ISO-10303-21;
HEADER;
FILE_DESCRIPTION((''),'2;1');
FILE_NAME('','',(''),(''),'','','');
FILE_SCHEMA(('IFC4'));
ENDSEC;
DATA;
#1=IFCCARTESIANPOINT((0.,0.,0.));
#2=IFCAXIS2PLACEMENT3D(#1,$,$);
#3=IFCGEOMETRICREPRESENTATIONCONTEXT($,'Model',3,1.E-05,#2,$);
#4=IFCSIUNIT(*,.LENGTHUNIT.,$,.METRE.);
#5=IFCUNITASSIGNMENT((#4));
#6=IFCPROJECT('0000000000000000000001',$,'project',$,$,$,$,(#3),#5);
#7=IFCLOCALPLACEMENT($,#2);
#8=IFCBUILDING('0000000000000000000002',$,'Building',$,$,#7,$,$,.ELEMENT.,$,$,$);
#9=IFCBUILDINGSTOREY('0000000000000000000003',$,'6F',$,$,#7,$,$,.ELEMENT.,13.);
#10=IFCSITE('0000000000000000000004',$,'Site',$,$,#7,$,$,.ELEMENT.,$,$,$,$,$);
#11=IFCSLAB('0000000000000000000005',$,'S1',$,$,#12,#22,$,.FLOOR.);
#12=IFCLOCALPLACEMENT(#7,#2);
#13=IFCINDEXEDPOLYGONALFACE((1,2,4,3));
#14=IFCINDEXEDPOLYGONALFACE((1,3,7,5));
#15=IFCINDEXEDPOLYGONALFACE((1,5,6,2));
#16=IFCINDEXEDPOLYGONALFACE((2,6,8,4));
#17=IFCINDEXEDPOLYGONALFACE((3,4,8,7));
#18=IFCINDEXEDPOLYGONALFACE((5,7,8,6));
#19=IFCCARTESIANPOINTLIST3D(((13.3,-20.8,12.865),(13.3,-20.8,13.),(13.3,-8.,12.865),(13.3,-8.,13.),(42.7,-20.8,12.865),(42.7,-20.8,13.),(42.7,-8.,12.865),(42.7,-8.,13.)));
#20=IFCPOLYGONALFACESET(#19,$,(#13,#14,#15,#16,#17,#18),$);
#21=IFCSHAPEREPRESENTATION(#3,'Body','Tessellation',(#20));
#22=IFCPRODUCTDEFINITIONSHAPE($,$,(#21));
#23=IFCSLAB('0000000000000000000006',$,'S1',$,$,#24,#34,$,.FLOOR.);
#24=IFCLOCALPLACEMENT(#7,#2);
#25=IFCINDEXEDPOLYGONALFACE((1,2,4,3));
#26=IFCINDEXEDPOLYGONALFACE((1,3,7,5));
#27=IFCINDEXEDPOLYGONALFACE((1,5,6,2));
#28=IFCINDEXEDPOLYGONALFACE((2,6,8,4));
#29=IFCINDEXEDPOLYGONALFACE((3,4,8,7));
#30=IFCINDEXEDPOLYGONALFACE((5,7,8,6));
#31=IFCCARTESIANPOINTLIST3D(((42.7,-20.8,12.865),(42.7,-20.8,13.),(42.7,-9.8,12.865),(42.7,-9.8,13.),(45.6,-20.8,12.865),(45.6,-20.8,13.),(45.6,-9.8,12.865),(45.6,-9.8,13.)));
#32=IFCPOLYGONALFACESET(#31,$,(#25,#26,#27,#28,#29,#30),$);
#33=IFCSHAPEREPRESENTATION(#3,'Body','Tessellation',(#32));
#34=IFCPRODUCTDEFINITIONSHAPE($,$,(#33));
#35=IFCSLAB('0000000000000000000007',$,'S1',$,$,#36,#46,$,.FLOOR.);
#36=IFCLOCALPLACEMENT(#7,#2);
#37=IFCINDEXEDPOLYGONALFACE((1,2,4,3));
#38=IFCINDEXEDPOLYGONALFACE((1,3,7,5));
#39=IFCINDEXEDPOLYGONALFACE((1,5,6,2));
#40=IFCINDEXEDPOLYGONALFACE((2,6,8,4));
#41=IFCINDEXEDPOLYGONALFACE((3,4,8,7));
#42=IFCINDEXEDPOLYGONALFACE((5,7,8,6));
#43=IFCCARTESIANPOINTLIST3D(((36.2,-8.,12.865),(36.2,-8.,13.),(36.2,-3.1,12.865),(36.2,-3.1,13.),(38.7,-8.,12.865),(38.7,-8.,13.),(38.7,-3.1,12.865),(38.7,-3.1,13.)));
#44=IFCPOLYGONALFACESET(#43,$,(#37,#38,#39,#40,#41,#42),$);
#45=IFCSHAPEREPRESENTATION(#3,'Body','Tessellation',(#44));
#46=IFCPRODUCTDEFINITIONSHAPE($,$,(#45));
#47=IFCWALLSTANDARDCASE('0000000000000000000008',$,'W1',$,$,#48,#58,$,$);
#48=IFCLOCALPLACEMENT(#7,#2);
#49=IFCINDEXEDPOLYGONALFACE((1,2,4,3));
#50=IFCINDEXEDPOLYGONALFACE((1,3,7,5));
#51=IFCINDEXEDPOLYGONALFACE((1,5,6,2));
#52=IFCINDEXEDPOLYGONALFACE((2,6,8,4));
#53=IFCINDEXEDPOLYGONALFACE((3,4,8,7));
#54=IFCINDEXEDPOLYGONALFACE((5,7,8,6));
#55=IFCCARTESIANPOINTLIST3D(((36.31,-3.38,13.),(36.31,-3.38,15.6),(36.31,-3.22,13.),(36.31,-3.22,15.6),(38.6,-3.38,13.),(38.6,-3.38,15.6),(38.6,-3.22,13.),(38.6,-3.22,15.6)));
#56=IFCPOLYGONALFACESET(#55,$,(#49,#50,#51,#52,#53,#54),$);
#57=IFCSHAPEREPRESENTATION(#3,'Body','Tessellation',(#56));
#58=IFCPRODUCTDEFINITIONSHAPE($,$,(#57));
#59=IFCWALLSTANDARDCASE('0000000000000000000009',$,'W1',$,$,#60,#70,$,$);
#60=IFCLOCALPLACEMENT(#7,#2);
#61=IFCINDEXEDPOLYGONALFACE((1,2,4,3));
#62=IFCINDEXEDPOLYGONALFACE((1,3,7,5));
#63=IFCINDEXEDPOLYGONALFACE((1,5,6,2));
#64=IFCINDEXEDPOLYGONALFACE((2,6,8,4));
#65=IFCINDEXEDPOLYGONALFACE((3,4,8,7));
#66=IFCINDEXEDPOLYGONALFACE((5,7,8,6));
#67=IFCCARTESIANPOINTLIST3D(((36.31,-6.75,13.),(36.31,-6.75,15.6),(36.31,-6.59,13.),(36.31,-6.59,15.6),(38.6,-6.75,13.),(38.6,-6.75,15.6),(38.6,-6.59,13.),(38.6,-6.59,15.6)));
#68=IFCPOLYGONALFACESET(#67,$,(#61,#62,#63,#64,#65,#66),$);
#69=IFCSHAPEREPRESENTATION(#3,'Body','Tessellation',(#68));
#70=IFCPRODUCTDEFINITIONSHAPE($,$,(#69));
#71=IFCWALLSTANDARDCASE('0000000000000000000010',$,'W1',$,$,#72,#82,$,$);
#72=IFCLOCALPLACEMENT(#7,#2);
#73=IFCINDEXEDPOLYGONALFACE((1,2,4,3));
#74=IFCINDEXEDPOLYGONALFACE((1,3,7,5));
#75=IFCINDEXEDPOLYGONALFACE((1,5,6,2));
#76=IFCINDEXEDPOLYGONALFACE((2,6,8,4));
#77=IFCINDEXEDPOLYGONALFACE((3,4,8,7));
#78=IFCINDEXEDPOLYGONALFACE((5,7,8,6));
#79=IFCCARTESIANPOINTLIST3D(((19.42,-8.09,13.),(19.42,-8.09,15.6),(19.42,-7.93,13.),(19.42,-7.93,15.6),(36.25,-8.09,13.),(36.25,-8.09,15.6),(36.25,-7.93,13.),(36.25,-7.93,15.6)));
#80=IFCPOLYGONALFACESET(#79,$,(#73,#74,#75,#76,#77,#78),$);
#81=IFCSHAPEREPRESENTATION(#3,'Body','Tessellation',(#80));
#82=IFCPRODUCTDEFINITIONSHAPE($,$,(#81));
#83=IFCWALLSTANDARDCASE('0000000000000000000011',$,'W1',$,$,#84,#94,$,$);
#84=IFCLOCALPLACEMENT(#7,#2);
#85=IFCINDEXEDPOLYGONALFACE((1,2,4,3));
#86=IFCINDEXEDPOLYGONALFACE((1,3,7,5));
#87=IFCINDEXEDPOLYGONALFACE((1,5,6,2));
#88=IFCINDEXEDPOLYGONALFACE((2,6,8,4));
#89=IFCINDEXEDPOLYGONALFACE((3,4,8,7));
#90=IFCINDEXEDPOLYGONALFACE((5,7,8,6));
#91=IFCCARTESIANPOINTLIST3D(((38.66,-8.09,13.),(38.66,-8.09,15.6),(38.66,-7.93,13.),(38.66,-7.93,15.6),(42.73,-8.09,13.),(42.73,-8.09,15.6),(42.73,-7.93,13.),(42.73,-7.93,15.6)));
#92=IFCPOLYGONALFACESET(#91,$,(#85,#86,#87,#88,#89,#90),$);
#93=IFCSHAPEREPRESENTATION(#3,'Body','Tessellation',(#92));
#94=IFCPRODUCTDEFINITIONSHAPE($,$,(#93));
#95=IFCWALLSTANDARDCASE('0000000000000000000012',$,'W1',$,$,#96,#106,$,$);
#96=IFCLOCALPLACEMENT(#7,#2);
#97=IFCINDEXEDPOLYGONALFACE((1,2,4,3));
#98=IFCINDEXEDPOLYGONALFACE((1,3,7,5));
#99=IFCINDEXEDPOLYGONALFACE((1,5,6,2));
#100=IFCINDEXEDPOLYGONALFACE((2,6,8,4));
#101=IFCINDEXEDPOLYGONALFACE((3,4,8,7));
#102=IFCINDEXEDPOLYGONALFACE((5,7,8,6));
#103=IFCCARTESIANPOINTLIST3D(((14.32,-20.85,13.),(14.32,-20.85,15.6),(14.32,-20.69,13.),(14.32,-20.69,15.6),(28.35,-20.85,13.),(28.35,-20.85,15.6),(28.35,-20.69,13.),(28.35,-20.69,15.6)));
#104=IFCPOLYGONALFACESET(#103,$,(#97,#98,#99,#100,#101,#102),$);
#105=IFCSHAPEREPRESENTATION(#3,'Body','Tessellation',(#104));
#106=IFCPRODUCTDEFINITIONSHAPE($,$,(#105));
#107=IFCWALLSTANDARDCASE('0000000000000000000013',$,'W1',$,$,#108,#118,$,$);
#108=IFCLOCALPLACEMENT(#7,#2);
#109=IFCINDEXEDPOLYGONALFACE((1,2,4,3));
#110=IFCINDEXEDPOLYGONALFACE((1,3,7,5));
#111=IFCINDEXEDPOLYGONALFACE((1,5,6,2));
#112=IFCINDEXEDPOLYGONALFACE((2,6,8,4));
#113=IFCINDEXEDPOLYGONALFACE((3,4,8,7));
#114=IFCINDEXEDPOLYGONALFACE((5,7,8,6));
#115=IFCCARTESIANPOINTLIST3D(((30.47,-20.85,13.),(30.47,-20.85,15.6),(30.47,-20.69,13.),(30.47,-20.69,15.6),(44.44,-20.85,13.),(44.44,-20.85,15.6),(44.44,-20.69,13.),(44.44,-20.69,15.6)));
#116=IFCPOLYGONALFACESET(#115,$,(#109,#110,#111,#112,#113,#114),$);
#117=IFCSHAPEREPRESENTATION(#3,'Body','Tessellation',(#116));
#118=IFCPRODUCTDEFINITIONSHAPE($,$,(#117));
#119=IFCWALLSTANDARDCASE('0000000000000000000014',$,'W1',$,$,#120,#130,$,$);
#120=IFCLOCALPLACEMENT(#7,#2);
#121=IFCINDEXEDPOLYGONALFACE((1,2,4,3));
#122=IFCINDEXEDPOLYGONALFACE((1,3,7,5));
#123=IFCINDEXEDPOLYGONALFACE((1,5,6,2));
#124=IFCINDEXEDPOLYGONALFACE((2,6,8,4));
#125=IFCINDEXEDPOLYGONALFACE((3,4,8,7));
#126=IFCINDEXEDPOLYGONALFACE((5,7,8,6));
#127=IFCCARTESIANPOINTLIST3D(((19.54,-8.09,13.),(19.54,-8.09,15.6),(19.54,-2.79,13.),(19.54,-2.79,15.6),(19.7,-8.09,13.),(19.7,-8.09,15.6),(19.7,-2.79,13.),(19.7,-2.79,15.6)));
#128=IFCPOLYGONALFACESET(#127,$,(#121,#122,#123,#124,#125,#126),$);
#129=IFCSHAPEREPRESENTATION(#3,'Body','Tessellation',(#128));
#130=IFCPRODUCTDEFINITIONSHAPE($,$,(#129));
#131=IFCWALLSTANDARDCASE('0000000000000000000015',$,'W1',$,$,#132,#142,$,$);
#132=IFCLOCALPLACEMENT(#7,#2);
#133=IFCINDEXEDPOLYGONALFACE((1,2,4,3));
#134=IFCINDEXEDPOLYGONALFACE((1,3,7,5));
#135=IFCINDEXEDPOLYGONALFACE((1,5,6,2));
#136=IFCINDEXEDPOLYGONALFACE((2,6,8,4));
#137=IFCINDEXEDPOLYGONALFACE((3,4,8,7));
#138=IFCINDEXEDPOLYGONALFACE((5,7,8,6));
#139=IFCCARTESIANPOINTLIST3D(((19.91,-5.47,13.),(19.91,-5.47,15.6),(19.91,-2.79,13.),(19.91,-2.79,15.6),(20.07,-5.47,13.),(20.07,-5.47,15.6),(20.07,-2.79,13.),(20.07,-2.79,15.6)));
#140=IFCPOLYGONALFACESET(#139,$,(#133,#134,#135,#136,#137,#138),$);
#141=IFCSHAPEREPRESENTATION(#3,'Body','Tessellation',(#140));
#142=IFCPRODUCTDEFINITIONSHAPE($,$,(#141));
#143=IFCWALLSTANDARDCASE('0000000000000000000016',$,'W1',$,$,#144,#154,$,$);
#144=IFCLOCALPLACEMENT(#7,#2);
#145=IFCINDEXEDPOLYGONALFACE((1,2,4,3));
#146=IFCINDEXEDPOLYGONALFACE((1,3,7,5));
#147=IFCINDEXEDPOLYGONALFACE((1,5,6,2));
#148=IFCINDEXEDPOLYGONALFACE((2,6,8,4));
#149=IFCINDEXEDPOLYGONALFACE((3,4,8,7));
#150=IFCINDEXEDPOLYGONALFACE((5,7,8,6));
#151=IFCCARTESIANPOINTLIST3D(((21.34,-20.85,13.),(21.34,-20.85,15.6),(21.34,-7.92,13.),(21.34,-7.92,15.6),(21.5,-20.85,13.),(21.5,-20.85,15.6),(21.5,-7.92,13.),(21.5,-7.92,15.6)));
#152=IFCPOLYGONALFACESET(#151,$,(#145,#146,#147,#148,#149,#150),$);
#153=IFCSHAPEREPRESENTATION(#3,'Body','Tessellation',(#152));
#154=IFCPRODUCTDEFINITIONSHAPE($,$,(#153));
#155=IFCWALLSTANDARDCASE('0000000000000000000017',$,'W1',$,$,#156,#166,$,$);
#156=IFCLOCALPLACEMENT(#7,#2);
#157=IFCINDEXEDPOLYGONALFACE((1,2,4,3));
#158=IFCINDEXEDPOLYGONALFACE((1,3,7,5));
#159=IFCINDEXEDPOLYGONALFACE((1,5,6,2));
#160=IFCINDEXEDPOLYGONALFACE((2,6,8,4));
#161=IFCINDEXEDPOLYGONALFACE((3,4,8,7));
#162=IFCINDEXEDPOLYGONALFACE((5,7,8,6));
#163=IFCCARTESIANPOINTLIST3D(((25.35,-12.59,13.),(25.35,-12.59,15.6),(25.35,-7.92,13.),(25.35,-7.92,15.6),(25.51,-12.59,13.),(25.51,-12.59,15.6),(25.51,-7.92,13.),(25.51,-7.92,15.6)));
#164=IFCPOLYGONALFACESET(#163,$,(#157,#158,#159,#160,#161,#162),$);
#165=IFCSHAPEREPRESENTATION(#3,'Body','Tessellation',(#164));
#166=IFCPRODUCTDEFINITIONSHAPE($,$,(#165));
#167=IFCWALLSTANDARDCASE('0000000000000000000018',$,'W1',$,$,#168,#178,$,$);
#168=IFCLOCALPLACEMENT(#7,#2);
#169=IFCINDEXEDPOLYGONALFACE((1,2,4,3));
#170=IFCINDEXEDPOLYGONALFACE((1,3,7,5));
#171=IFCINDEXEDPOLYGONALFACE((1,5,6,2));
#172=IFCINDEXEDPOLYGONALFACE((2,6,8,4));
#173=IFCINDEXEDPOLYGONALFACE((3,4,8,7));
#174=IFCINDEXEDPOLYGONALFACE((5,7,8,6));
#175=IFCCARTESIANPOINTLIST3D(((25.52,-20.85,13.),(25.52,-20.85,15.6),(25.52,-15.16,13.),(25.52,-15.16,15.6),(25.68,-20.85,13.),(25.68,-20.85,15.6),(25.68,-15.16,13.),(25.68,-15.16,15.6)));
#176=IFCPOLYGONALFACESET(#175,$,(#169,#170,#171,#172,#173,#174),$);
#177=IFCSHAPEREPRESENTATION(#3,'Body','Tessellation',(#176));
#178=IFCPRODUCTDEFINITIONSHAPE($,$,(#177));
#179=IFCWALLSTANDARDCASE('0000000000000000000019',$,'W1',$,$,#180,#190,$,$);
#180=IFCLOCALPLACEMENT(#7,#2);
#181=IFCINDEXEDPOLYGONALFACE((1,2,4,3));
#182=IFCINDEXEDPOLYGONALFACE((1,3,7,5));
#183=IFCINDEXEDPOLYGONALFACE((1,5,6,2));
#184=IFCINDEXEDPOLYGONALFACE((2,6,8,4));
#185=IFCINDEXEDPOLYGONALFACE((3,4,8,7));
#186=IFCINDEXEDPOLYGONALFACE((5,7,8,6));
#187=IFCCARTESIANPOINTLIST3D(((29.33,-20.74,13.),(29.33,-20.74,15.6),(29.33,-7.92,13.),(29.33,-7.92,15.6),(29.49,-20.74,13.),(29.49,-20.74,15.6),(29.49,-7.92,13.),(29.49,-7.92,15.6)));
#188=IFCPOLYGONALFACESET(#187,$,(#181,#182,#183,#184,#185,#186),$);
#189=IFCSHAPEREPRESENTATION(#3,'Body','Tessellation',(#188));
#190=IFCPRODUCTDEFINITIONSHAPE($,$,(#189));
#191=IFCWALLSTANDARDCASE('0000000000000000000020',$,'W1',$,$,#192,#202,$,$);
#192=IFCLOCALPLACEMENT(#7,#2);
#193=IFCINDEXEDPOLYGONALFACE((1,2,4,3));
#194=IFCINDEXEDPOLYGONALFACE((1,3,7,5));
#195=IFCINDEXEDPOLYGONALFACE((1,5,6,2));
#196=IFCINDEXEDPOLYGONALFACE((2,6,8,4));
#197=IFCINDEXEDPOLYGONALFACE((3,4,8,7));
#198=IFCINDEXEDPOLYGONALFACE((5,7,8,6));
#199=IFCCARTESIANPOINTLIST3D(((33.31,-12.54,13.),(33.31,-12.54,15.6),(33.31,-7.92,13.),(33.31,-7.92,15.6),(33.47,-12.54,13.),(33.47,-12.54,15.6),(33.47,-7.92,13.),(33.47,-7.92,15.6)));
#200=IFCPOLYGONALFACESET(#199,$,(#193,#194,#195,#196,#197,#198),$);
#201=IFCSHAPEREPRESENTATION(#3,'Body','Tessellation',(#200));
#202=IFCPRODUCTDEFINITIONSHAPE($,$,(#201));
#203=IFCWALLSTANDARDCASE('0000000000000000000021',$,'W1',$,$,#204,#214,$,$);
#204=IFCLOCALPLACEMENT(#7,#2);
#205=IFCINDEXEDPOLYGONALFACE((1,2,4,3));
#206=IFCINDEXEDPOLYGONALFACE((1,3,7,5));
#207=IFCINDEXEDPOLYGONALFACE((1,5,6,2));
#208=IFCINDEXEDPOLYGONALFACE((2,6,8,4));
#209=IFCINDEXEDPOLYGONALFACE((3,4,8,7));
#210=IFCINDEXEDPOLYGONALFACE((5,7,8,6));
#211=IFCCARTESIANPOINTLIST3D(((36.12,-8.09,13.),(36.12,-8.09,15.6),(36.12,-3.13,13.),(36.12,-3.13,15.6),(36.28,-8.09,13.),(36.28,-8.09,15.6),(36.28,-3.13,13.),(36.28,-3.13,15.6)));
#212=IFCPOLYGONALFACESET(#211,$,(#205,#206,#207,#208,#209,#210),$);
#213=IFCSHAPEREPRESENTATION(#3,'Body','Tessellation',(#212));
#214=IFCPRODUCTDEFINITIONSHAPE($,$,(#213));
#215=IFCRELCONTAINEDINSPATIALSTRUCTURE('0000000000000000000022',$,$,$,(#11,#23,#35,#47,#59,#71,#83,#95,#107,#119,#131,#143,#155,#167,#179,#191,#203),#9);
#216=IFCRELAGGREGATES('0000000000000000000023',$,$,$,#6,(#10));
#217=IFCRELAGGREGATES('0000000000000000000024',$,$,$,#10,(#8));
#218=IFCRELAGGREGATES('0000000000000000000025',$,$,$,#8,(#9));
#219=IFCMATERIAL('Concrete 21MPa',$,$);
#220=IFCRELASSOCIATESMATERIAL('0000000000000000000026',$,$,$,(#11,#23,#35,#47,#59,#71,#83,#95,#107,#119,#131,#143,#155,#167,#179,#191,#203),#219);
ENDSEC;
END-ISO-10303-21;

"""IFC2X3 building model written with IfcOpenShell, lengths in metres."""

from ifc_helpers import new_model, si_unit, frame, origin, origin_2d, place, context, project, spatial, rectangle, extrude, material, element, save


model = new_model("IFC2X3")

# Units and contexts
model_context = context("Model", 3, precision=1e-05, world=origin())
ifc_project = project(units=[si_unit("LENGTHUNIT", "METRE")], contexts=[model_context])

# Site, building, storey
placement = place(None, origin())
site = spatial("IfcSite", under=ifc_project, at=placement, Name="Site", CompositionType="ELEMENT")
building = spatial("IfcBuilding", under=site, at=placement, Name="Building", CompositionType="ELEMENT")
storey = spatial("IfcBuildingStorey", under=building, at=placement, Name="6F", CompositionType="ELEMENT", Elevation=13.0)

# Slabs
ifc_material_1 = material(Name="Concrete 21MPa")
slab_1_placement = place(None, frame((28.0, -14.4, 12.865)))
element("IfcSlab", 1, at=slab_1_placement, inside=storey, material=ifc_material_1, Name="S1", PredefinedType="FLOOR", context=model_context, shape_type="SweptSolid", body=[
    extrude(rectangle(XDim=29.4, YDim=12.8, at=origin_2d()), origin(), (0.0, 0.0, 1.0), 0.135),
])
slab_2_placement = place(None, frame((44.15, -15.3, 12.865)))
element("IfcSlab", 2, at=slab_2_placement, inside=storey, material=ifc_material_1, Name="S1", PredefinedType="FLOOR", context=model_context, shape_type="SweptSolid", body=[
    extrude(rectangle(XDim=2.9, YDim=11.0, at=origin_2d()), origin(), (0.0, 0.0, 1.0), 0.135),
])
slab_3_placement = place(None, frame((37.45, -5.55, 12.865)))
element("IfcSlab", 3, at=slab_3_placement, inside=storey, material=ifc_material_1, Name="S1", PredefinedType="FLOOR", context=model_context, shape_type="SweptSolid", body=[
    extrude(rectangle(XDim=2.5, YDim=4.9, at=origin_2d()), origin(), (0.0, 0.0, 1.0), 0.135),
])

# Walls
for number, where, name in (
    (4, (37.455, -3.3, 13.0), "W1"),
    (5, (37.455, -6.67, 13.0), "W1"),
):
    element("IfcWallStandardCase", number, at=place(None, frame(where)), inside=storey, material=ifc_material_1, Name=name, context=model_context, shape_type="SweptSolid", body=[
        extrude(rectangle(XDim=2.29, YDim=0.16, at=origin_2d()), origin(), (0.0, 0.0, 1.0), 2.6),
    ])
wall_1_placement = place(None, frame((27.835, -8.01, 13.0)))
element("IfcWallStandardCase", 6, at=wall_1_placement, inside=storey, material=ifc_material_1, Name="W1", context=model_context, shape_type="SweptSolid", body=[
    extrude(rectangle(XDim=16.83, YDim=0.16, at=origin_2d()), origin(), (0.0, 0.0, 1.0), 2.6),
])
wall_2_placement = place(None, frame((40.695, -8.01, 13.0)))
element("IfcWallStandardCase", 7, at=wall_2_placement, inside=storey, material=ifc_material_1, Name="W1", context=model_context, shape_type="SweptSolid", body=[
    extrude(rectangle(XDim=4.07, YDim=0.16, at=origin_2d()), origin(), (0.0, 0.0, 1.0), 2.6),
])
wall_3_placement = place(None, frame((21.335, -20.77, 13.0)))
element("IfcWallStandardCase", 8, at=wall_3_placement, inside=storey, material=ifc_material_1, Name="W1", context=model_context, shape_type="SweptSolid", body=[
    extrude(rectangle(XDim=14.03, YDim=0.16, at=origin_2d()), origin(), (0.0, 0.0, 1.0), 2.6),
])
wall_4_placement = place(None, frame((37.455, -20.77, 13.0)))
element("IfcWallStandardCase", 9, at=wall_4_placement, inside=storey, material=ifc_material_1, Name="W1", context=model_context, shape_type="SweptSolid", body=[
    extrude(rectangle(XDim=13.97, YDim=0.16, at=origin_2d()), origin(), (0.0, 0.0, 1.0), 2.6),
])
wall_5_placement = place(None, frame((19.62, -5.44, 13.0)))
element("IfcWallStandardCase", 10, at=wall_5_placement, inside=storey, material=ifc_material_1, Name="W1", context=model_context, shape_type="SweptSolid", body=[
    extrude(rectangle(XDim=0.16, YDim=5.3, at=origin_2d()), origin(), (0.0, 0.0, 1.0), 2.6),
])
wall_6_placement = place(None, frame((19.99, -4.13, 13.0)))
element("IfcWallStandardCase", 11, at=wall_6_placement, inside=storey, material=ifc_material_1, Name="W1", context=model_context, shape_type="SweptSolid", body=[
    extrude(rectangle(XDim=0.16, YDim=2.68, at=origin_2d()), origin(), (0.0, 0.0, 1.0), 2.6),
])
wall_7_placement = place(None, frame((21.42, -14.385, 13.0)))
element("IfcWallStandardCase", 12, at=wall_7_placement, inside=storey, material=ifc_material_1, Name="W1", context=model_context, shape_type="SweptSolid", body=[
    extrude(rectangle(XDim=0.16, YDim=12.93, at=origin_2d()), origin(), (0.0, 0.0, 1.0), 2.6),
])
wall_8_placement = place(None, frame((25.43, -10.255, 13.0)))
element("IfcWallStandardCase", 13, at=wall_8_placement, inside=storey, material=ifc_material_1, Name="W1", context=model_context, shape_type="SweptSolid", body=[
    extrude(rectangle(XDim=0.16, YDim=4.67, at=origin_2d()), origin(), (0.0, 0.0, 1.0), 2.6),
])
wall_9_placement = place(None, frame((25.6, -18.005, 13.0)))
element("IfcWallStandardCase", 14, at=wall_9_placement, inside=storey, material=ifc_material_1, Name="W1", context=model_context, shape_type="SweptSolid", body=[
    extrude(rectangle(XDim=0.16, YDim=5.69, at=origin_2d()), origin(), (0.0, 0.0, 1.0), 2.6),
])
wall_10_placement = place(None, frame((29.41, -14.33, 13.0)))
element("IfcWallStandardCase", 15, at=wall_10_placement, inside=storey, material=ifc_material_1, Name="W1", context=model_context, shape_type="SweptSolid", body=[
    extrude(rectangle(XDim=0.16, YDim=12.82, at=origin_2d()), origin(), (0.0, 0.0, 1.0), 2.6),
])
wall_11_placement = place(None, frame((33.39, -10.23, 13.0)))
element("IfcWallStandardCase", 16, at=wall_11_placement, inside=storey, material=ifc_material_1, Name="W1", context=model_context, shape_type="SweptSolid", body=[
    extrude(rectangle(XDim=0.16, YDim=4.62, at=origin_2d()), origin(), (0.0, 0.0, 1.0), 2.6),
])
wall_12_placement = place(None, frame((36.2, -5.61, 13.0)))
element("IfcWallStandardCase", 17, at=wall_12_placement, inside=storey, material=ifc_material_1, Name="W1", context=model_context, shape_type="SweptSolid", body=[
    extrude(rectangle(XDim=0.16, YDim=4.96, at=origin_2d()), origin(), (0.0, 0.0, 1.0), 2.6),
])

save(model, "model.ifc")
